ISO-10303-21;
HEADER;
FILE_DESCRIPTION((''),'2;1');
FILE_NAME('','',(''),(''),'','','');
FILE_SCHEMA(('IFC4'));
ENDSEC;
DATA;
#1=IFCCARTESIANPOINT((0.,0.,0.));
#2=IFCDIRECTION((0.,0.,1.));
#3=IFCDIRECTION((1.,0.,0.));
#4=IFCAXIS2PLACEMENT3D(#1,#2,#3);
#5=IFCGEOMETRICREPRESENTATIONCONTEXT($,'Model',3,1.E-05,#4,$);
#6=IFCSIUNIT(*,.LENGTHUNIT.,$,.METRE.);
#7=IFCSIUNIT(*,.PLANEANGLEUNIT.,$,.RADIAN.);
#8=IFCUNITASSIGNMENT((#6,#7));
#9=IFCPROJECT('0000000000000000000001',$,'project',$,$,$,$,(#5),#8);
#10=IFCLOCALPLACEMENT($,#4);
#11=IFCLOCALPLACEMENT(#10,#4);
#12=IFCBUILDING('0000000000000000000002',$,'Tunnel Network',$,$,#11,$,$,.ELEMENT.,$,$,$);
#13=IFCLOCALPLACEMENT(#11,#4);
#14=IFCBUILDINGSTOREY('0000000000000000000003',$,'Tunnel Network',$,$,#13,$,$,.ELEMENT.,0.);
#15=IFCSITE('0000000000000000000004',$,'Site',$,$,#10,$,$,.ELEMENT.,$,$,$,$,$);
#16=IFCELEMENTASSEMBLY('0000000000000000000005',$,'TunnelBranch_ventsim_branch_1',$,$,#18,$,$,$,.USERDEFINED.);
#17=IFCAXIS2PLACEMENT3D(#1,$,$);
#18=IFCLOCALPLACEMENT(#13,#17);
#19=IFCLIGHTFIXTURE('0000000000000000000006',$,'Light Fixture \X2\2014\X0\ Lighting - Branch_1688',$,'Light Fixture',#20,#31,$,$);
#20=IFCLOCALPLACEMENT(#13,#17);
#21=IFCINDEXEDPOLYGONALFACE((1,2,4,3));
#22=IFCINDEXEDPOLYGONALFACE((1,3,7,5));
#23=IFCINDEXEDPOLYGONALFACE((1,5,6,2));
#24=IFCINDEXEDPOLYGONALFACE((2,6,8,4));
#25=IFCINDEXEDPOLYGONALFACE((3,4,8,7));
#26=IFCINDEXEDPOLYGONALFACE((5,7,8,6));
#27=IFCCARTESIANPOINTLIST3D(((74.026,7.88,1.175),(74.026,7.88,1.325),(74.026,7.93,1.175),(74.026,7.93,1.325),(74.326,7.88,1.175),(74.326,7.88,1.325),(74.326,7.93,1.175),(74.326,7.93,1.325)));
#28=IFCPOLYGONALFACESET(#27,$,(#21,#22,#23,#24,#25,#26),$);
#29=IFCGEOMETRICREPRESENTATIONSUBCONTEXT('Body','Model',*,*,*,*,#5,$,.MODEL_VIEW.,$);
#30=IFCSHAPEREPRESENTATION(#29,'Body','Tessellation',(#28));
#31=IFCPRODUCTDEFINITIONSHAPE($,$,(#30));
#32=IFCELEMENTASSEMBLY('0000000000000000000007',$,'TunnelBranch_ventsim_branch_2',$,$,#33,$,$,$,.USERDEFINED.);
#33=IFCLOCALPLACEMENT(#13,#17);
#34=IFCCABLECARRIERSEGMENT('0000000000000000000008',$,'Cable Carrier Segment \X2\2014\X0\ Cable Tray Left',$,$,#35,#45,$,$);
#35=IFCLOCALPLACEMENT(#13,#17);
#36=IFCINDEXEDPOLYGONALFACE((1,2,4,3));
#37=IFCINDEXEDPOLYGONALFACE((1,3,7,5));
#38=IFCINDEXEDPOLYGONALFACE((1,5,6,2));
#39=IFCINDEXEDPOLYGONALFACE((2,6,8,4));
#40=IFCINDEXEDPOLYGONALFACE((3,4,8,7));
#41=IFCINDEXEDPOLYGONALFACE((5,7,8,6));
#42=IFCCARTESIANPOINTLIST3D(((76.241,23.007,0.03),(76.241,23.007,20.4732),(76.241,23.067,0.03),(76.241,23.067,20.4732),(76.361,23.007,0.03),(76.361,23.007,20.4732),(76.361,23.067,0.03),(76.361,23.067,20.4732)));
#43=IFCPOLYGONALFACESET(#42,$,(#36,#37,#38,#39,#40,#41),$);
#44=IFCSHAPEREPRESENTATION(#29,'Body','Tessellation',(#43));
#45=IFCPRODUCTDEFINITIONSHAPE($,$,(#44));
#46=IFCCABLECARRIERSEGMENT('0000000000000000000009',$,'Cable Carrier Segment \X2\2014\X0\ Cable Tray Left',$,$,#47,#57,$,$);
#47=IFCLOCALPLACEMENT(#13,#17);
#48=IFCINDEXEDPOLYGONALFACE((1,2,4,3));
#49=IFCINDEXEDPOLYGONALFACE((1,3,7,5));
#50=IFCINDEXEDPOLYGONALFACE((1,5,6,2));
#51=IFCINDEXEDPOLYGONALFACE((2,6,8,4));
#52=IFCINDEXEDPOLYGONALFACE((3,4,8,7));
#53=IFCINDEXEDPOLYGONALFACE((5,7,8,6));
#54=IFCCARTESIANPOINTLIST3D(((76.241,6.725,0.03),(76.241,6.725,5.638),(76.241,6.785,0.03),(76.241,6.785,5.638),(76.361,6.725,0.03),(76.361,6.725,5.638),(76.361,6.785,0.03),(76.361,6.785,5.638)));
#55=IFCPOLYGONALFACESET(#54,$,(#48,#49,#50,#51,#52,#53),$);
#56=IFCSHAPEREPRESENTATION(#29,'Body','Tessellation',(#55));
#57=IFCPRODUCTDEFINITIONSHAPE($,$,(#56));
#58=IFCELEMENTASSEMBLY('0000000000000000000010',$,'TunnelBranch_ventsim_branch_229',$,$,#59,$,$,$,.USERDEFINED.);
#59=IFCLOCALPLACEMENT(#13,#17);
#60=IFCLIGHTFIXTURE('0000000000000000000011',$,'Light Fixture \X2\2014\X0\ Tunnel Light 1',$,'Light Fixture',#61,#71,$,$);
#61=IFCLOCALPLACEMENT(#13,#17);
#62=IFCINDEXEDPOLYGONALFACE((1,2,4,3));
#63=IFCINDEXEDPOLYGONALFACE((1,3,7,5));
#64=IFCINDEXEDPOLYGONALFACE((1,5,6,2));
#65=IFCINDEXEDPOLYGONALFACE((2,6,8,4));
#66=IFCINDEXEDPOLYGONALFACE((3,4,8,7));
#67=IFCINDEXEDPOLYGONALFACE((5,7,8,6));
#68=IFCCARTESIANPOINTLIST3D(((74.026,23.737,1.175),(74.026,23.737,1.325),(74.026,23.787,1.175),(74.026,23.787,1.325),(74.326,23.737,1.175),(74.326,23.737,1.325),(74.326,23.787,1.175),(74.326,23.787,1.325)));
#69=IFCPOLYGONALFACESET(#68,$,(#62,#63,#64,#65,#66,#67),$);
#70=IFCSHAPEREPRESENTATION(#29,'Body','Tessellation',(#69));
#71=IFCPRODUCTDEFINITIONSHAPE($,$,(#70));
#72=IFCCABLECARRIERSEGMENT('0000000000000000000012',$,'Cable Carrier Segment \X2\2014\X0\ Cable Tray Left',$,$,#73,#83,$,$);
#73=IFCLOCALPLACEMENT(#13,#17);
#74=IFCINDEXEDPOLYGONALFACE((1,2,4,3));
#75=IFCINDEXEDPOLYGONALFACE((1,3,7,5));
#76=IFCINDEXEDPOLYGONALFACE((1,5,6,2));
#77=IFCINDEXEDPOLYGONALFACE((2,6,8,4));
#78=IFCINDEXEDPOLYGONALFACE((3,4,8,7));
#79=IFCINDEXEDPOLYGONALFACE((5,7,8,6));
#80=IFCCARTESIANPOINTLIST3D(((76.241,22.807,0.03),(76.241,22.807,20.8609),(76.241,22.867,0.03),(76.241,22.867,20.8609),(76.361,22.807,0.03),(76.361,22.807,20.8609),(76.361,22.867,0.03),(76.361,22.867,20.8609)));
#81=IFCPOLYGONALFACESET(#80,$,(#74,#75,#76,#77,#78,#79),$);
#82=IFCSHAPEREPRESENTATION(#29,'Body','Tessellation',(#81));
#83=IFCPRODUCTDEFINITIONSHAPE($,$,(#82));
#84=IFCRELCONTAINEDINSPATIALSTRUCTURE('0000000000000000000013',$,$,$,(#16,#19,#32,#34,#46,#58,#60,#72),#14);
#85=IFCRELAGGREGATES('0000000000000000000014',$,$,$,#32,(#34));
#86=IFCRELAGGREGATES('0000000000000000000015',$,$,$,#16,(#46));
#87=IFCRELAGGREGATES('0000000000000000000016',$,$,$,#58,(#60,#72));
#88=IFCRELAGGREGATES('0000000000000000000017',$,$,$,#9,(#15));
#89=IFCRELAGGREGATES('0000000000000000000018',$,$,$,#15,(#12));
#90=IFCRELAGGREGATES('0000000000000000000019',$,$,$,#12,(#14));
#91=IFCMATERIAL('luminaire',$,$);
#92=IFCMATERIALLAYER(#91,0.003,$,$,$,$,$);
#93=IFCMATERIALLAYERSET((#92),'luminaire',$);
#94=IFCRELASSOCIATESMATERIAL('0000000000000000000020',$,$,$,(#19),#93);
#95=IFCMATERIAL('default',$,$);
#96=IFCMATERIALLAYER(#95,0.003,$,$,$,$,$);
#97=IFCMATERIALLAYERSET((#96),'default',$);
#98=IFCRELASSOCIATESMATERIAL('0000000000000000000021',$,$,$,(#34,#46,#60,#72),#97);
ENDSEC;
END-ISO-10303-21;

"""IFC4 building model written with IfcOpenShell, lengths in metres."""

from ifc_helpers import new_model, si_unit, frame, origin_with_axes, origin_2d_with_axis, place, context, subcontext, project, spatial, rectangle, extrude, material, layer, layer_set, layer_usage, element, aggregate, save


model = new_model("IFC4")

# Units and contexts
model_context = context("Model", 3, precision=1e-05, world=origin_with_axes())
body_context = subcontext(model_context, "Body", "Model", "MODEL_VIEW")
ifc_project = project(units=[si_unit("LENGTHUNIT", "METRE"), si_unit("PLANEANGLEUNIT", "RADIAN")], contexts=[model_context])

# Site, building, storey
site_placement = place(None, origin_with_axes())
site = spatial("IfcSite", under=ifc_project, at=site_placement, Name="Site", CompositionType="ELEMENT")
building_placement = place(site_placement, origin_with_axes())
building = spatial("IfcBuilding", under=site, at=building_placement, Name="Tunnel Network", CompositionType="ELEMENT")
storey_placement = place(building_placement, origin_with_axes())
storey = spatial("IfcBuildingStorey", under=building, at=storey_placement, Name="Tunnel Network", CompositionType="ELEMENT", Elevation=0.0)

# Element assembly
assembly_1_placement = place(storey_placement, frame((74.176, 7.88, 0.701), z_axis=(0.0, 0.0, 1.0), x_axis=(-1.0, 0.0, 0.0)))
assembly_1 = element("IfcElementAssembly", 1, at=assembly_1_placement, inside=storey, Name="TunnelBranch_ventsim_branch_1", PredefinedType="USERDEFINED")
ifc_material_1 = material(Name="default")
ifc_layer_1 = layer(ifc_material_1, 0.003)
ifc_layer_set_1 = layer_set([ifc_layer_1], Name="default")

# Light fixture
ifc_material_2 = material(Name="luminaire")
ifc_layer_2 = layer(ifc_material_2, 0.003)
ifc_layer_set_2 = layer_set([ifc_layer_2], Name="luminaire")
ifc_layer_usage_1 = layer_usage(ifc_layer_set_2, "AXIS2", "POSITIVE", 0.0)
light_fixture_1_placement = place(storey_placement, frame((74.176, 7.88, 1.25), z_axis=(0.0, 1.0, 0.0), x_axis=(-1.0, 0.0, 0.0)))
element("IfcLightFixture", 2, at=light_fixture_1_placement, inside=storey, material=ifc_layer_usage_1, Name="Light Fixture — Lighting - Branch_1688", ObjectType="Light Fixture", context=body_context, shape_type="SweptSolid", body=[
    extrude(rectangle(XDim=0.3, YDim=0.15, at=origin_2d_with_axis()), origin_with_axes(), (0.0, 0.0, 1.0), 0.05),
])

# Element assembly, cable carrier segment
assembly_2_placement = place(storey_placement, frame((74.176, 24.162, 1.25), z_axis=(0.0, 1.0, 0.0), x_axis=(-1.0, 0.0, 0.0)))
assembly_2 = element("IfcElementAssembly", 3, at=assembly_2_placement, inside=storey, Name="TunnelBranch_ventsim_branch_2", PredefinedType="USERDEFINED")
ifc_layer_usage_2 = layer_usage(ifc_layer_set_1, "AXIS2", "POSITIVE", 0.0)
cable_carrier_segment_1_placement = place(storey_placement, frame((76.301, 23.037, 0.03), z_axis=(0.0, 0.0, 1.0), x_axis=(-1.0, 0.0, 0.0)))
cable_carrier_segment_1 = element("IfcCableCarrierSegment", 4, at=cable_carrier_segment_1_placement, inside=storey, material=ifc_layer_usage_2, Name="Cable Carrier Segment — Cable Tray Left", context=body_context, shape_type="SweptSolid", body=[
    extrude(rectangle(XDim=0.12, YDim=0.06, at=origin_2d_with_axis()), origin_with_axes(), (0.0, 0.0, 1.0), 20.4432),
])
aggregate(assembly_2, [cable_carrier_segment_1])

# Cable carrier segment
ifc_layer_usage_3 = layer_usage(ifc_layer_set_1, "AXIS2", "POSITIVE", 0.0)
cable_carrier_segment_2_placement = place(storey_placement, frame((76.301, 6.755, 0.03), z_axis=(0.0, 0.0, 1.0), x_axis=(-1.0, 0.0, 0.0)))
cable_carrier_segment_2 = element("IfcCableCarrierSegment", 5, at=cable_carrier_segment_2_placement, inside=storey, material=ifc_layer_usage_3, Name="Cable Carrier Segment — Cable Tray Left", context=body_context, shape_type="SweptSolid", body=[
    extrude(rectangle(XDim=0.12, YDim=0.06, at=origin_2d_with_axis()), origin_with_axes(), (0.0, 0.0, 1.0), 5.608),
])
aggregate(assembly_1, [cable_carrier_segment_2])

# Element assembly, light fixture, cable carrier segment
assembly_3_placement = place(storey_placement, frame((74.176, 23.737, 1.25), z_axis=(0.0, 1.0, 0.0), x_axis=(-1.0, 0.0, 0.0)))
assembly_3 = element("IfcElementAssembly", 6, at=assembly_3_placement, inside=storey, Name="TunnelBranch_ventsim_branch_229", PredefinedType="USERDEFINED")
ifc_layer_usage_4 = layer_usage(ifc_layer_set_1, "AXIS2", "POSITIVE", 0.0)
light_fixture_2_placement = place(storey_placement, frame((74.176, 23.737, 1.25), z_axis=(0.0, 1.0, 0.0), x_axis=(-1.0, 0.0, 0.0)))
light_fixture_2 = element("IfcLightFixture", 7, at=light_fixture_2_placement, inside=storey, material=ifc_layer_usage_4, Name="Light Fixture — Tunnel Light 1", ObjectType="Light Fixture", context=body_context, shape_type="SweptSolid", body=[
    extrude(rectangle(XDim=0.3, YDim=0.15, at=origin_2d_with_axis()), origin_with_axes(), (0.0, 0.0, 1.0), 0.05),
])
ifc_layer_usage_5 = layer_usage(ifc_layer_set_1, "AXIS2", "POSITIVE", 0.0)
cable_carrier_segment_3_placement = place(storey_placement, frame((76.301, 22.837, 0.03), z_axis=(0.0, 0.0, 1.0), x_axis=(-1.0, 0.0, 0.0)))
cable_carrier_segment_3 = element("IfcCableCarrierSegment", 8, at=cable_carrier_segment_3_placement, inside=storey, material=ifc_layer_usage_5, Name="Cable Carrier Segment — Cable Tray Left", context=body_context, shape_type="SweptSolid", body=[
    extrude(rectangle(XDim=0.12, YDim=0.06, at=origin_2d_with_axis()), origin_with_axes(), (0.0, 0.0, 1.0), 20.8309),
])
aggregate(assembly_3, [light_fixture_2, cable_carrier_segment_3])

save(model, "model.ifc")
